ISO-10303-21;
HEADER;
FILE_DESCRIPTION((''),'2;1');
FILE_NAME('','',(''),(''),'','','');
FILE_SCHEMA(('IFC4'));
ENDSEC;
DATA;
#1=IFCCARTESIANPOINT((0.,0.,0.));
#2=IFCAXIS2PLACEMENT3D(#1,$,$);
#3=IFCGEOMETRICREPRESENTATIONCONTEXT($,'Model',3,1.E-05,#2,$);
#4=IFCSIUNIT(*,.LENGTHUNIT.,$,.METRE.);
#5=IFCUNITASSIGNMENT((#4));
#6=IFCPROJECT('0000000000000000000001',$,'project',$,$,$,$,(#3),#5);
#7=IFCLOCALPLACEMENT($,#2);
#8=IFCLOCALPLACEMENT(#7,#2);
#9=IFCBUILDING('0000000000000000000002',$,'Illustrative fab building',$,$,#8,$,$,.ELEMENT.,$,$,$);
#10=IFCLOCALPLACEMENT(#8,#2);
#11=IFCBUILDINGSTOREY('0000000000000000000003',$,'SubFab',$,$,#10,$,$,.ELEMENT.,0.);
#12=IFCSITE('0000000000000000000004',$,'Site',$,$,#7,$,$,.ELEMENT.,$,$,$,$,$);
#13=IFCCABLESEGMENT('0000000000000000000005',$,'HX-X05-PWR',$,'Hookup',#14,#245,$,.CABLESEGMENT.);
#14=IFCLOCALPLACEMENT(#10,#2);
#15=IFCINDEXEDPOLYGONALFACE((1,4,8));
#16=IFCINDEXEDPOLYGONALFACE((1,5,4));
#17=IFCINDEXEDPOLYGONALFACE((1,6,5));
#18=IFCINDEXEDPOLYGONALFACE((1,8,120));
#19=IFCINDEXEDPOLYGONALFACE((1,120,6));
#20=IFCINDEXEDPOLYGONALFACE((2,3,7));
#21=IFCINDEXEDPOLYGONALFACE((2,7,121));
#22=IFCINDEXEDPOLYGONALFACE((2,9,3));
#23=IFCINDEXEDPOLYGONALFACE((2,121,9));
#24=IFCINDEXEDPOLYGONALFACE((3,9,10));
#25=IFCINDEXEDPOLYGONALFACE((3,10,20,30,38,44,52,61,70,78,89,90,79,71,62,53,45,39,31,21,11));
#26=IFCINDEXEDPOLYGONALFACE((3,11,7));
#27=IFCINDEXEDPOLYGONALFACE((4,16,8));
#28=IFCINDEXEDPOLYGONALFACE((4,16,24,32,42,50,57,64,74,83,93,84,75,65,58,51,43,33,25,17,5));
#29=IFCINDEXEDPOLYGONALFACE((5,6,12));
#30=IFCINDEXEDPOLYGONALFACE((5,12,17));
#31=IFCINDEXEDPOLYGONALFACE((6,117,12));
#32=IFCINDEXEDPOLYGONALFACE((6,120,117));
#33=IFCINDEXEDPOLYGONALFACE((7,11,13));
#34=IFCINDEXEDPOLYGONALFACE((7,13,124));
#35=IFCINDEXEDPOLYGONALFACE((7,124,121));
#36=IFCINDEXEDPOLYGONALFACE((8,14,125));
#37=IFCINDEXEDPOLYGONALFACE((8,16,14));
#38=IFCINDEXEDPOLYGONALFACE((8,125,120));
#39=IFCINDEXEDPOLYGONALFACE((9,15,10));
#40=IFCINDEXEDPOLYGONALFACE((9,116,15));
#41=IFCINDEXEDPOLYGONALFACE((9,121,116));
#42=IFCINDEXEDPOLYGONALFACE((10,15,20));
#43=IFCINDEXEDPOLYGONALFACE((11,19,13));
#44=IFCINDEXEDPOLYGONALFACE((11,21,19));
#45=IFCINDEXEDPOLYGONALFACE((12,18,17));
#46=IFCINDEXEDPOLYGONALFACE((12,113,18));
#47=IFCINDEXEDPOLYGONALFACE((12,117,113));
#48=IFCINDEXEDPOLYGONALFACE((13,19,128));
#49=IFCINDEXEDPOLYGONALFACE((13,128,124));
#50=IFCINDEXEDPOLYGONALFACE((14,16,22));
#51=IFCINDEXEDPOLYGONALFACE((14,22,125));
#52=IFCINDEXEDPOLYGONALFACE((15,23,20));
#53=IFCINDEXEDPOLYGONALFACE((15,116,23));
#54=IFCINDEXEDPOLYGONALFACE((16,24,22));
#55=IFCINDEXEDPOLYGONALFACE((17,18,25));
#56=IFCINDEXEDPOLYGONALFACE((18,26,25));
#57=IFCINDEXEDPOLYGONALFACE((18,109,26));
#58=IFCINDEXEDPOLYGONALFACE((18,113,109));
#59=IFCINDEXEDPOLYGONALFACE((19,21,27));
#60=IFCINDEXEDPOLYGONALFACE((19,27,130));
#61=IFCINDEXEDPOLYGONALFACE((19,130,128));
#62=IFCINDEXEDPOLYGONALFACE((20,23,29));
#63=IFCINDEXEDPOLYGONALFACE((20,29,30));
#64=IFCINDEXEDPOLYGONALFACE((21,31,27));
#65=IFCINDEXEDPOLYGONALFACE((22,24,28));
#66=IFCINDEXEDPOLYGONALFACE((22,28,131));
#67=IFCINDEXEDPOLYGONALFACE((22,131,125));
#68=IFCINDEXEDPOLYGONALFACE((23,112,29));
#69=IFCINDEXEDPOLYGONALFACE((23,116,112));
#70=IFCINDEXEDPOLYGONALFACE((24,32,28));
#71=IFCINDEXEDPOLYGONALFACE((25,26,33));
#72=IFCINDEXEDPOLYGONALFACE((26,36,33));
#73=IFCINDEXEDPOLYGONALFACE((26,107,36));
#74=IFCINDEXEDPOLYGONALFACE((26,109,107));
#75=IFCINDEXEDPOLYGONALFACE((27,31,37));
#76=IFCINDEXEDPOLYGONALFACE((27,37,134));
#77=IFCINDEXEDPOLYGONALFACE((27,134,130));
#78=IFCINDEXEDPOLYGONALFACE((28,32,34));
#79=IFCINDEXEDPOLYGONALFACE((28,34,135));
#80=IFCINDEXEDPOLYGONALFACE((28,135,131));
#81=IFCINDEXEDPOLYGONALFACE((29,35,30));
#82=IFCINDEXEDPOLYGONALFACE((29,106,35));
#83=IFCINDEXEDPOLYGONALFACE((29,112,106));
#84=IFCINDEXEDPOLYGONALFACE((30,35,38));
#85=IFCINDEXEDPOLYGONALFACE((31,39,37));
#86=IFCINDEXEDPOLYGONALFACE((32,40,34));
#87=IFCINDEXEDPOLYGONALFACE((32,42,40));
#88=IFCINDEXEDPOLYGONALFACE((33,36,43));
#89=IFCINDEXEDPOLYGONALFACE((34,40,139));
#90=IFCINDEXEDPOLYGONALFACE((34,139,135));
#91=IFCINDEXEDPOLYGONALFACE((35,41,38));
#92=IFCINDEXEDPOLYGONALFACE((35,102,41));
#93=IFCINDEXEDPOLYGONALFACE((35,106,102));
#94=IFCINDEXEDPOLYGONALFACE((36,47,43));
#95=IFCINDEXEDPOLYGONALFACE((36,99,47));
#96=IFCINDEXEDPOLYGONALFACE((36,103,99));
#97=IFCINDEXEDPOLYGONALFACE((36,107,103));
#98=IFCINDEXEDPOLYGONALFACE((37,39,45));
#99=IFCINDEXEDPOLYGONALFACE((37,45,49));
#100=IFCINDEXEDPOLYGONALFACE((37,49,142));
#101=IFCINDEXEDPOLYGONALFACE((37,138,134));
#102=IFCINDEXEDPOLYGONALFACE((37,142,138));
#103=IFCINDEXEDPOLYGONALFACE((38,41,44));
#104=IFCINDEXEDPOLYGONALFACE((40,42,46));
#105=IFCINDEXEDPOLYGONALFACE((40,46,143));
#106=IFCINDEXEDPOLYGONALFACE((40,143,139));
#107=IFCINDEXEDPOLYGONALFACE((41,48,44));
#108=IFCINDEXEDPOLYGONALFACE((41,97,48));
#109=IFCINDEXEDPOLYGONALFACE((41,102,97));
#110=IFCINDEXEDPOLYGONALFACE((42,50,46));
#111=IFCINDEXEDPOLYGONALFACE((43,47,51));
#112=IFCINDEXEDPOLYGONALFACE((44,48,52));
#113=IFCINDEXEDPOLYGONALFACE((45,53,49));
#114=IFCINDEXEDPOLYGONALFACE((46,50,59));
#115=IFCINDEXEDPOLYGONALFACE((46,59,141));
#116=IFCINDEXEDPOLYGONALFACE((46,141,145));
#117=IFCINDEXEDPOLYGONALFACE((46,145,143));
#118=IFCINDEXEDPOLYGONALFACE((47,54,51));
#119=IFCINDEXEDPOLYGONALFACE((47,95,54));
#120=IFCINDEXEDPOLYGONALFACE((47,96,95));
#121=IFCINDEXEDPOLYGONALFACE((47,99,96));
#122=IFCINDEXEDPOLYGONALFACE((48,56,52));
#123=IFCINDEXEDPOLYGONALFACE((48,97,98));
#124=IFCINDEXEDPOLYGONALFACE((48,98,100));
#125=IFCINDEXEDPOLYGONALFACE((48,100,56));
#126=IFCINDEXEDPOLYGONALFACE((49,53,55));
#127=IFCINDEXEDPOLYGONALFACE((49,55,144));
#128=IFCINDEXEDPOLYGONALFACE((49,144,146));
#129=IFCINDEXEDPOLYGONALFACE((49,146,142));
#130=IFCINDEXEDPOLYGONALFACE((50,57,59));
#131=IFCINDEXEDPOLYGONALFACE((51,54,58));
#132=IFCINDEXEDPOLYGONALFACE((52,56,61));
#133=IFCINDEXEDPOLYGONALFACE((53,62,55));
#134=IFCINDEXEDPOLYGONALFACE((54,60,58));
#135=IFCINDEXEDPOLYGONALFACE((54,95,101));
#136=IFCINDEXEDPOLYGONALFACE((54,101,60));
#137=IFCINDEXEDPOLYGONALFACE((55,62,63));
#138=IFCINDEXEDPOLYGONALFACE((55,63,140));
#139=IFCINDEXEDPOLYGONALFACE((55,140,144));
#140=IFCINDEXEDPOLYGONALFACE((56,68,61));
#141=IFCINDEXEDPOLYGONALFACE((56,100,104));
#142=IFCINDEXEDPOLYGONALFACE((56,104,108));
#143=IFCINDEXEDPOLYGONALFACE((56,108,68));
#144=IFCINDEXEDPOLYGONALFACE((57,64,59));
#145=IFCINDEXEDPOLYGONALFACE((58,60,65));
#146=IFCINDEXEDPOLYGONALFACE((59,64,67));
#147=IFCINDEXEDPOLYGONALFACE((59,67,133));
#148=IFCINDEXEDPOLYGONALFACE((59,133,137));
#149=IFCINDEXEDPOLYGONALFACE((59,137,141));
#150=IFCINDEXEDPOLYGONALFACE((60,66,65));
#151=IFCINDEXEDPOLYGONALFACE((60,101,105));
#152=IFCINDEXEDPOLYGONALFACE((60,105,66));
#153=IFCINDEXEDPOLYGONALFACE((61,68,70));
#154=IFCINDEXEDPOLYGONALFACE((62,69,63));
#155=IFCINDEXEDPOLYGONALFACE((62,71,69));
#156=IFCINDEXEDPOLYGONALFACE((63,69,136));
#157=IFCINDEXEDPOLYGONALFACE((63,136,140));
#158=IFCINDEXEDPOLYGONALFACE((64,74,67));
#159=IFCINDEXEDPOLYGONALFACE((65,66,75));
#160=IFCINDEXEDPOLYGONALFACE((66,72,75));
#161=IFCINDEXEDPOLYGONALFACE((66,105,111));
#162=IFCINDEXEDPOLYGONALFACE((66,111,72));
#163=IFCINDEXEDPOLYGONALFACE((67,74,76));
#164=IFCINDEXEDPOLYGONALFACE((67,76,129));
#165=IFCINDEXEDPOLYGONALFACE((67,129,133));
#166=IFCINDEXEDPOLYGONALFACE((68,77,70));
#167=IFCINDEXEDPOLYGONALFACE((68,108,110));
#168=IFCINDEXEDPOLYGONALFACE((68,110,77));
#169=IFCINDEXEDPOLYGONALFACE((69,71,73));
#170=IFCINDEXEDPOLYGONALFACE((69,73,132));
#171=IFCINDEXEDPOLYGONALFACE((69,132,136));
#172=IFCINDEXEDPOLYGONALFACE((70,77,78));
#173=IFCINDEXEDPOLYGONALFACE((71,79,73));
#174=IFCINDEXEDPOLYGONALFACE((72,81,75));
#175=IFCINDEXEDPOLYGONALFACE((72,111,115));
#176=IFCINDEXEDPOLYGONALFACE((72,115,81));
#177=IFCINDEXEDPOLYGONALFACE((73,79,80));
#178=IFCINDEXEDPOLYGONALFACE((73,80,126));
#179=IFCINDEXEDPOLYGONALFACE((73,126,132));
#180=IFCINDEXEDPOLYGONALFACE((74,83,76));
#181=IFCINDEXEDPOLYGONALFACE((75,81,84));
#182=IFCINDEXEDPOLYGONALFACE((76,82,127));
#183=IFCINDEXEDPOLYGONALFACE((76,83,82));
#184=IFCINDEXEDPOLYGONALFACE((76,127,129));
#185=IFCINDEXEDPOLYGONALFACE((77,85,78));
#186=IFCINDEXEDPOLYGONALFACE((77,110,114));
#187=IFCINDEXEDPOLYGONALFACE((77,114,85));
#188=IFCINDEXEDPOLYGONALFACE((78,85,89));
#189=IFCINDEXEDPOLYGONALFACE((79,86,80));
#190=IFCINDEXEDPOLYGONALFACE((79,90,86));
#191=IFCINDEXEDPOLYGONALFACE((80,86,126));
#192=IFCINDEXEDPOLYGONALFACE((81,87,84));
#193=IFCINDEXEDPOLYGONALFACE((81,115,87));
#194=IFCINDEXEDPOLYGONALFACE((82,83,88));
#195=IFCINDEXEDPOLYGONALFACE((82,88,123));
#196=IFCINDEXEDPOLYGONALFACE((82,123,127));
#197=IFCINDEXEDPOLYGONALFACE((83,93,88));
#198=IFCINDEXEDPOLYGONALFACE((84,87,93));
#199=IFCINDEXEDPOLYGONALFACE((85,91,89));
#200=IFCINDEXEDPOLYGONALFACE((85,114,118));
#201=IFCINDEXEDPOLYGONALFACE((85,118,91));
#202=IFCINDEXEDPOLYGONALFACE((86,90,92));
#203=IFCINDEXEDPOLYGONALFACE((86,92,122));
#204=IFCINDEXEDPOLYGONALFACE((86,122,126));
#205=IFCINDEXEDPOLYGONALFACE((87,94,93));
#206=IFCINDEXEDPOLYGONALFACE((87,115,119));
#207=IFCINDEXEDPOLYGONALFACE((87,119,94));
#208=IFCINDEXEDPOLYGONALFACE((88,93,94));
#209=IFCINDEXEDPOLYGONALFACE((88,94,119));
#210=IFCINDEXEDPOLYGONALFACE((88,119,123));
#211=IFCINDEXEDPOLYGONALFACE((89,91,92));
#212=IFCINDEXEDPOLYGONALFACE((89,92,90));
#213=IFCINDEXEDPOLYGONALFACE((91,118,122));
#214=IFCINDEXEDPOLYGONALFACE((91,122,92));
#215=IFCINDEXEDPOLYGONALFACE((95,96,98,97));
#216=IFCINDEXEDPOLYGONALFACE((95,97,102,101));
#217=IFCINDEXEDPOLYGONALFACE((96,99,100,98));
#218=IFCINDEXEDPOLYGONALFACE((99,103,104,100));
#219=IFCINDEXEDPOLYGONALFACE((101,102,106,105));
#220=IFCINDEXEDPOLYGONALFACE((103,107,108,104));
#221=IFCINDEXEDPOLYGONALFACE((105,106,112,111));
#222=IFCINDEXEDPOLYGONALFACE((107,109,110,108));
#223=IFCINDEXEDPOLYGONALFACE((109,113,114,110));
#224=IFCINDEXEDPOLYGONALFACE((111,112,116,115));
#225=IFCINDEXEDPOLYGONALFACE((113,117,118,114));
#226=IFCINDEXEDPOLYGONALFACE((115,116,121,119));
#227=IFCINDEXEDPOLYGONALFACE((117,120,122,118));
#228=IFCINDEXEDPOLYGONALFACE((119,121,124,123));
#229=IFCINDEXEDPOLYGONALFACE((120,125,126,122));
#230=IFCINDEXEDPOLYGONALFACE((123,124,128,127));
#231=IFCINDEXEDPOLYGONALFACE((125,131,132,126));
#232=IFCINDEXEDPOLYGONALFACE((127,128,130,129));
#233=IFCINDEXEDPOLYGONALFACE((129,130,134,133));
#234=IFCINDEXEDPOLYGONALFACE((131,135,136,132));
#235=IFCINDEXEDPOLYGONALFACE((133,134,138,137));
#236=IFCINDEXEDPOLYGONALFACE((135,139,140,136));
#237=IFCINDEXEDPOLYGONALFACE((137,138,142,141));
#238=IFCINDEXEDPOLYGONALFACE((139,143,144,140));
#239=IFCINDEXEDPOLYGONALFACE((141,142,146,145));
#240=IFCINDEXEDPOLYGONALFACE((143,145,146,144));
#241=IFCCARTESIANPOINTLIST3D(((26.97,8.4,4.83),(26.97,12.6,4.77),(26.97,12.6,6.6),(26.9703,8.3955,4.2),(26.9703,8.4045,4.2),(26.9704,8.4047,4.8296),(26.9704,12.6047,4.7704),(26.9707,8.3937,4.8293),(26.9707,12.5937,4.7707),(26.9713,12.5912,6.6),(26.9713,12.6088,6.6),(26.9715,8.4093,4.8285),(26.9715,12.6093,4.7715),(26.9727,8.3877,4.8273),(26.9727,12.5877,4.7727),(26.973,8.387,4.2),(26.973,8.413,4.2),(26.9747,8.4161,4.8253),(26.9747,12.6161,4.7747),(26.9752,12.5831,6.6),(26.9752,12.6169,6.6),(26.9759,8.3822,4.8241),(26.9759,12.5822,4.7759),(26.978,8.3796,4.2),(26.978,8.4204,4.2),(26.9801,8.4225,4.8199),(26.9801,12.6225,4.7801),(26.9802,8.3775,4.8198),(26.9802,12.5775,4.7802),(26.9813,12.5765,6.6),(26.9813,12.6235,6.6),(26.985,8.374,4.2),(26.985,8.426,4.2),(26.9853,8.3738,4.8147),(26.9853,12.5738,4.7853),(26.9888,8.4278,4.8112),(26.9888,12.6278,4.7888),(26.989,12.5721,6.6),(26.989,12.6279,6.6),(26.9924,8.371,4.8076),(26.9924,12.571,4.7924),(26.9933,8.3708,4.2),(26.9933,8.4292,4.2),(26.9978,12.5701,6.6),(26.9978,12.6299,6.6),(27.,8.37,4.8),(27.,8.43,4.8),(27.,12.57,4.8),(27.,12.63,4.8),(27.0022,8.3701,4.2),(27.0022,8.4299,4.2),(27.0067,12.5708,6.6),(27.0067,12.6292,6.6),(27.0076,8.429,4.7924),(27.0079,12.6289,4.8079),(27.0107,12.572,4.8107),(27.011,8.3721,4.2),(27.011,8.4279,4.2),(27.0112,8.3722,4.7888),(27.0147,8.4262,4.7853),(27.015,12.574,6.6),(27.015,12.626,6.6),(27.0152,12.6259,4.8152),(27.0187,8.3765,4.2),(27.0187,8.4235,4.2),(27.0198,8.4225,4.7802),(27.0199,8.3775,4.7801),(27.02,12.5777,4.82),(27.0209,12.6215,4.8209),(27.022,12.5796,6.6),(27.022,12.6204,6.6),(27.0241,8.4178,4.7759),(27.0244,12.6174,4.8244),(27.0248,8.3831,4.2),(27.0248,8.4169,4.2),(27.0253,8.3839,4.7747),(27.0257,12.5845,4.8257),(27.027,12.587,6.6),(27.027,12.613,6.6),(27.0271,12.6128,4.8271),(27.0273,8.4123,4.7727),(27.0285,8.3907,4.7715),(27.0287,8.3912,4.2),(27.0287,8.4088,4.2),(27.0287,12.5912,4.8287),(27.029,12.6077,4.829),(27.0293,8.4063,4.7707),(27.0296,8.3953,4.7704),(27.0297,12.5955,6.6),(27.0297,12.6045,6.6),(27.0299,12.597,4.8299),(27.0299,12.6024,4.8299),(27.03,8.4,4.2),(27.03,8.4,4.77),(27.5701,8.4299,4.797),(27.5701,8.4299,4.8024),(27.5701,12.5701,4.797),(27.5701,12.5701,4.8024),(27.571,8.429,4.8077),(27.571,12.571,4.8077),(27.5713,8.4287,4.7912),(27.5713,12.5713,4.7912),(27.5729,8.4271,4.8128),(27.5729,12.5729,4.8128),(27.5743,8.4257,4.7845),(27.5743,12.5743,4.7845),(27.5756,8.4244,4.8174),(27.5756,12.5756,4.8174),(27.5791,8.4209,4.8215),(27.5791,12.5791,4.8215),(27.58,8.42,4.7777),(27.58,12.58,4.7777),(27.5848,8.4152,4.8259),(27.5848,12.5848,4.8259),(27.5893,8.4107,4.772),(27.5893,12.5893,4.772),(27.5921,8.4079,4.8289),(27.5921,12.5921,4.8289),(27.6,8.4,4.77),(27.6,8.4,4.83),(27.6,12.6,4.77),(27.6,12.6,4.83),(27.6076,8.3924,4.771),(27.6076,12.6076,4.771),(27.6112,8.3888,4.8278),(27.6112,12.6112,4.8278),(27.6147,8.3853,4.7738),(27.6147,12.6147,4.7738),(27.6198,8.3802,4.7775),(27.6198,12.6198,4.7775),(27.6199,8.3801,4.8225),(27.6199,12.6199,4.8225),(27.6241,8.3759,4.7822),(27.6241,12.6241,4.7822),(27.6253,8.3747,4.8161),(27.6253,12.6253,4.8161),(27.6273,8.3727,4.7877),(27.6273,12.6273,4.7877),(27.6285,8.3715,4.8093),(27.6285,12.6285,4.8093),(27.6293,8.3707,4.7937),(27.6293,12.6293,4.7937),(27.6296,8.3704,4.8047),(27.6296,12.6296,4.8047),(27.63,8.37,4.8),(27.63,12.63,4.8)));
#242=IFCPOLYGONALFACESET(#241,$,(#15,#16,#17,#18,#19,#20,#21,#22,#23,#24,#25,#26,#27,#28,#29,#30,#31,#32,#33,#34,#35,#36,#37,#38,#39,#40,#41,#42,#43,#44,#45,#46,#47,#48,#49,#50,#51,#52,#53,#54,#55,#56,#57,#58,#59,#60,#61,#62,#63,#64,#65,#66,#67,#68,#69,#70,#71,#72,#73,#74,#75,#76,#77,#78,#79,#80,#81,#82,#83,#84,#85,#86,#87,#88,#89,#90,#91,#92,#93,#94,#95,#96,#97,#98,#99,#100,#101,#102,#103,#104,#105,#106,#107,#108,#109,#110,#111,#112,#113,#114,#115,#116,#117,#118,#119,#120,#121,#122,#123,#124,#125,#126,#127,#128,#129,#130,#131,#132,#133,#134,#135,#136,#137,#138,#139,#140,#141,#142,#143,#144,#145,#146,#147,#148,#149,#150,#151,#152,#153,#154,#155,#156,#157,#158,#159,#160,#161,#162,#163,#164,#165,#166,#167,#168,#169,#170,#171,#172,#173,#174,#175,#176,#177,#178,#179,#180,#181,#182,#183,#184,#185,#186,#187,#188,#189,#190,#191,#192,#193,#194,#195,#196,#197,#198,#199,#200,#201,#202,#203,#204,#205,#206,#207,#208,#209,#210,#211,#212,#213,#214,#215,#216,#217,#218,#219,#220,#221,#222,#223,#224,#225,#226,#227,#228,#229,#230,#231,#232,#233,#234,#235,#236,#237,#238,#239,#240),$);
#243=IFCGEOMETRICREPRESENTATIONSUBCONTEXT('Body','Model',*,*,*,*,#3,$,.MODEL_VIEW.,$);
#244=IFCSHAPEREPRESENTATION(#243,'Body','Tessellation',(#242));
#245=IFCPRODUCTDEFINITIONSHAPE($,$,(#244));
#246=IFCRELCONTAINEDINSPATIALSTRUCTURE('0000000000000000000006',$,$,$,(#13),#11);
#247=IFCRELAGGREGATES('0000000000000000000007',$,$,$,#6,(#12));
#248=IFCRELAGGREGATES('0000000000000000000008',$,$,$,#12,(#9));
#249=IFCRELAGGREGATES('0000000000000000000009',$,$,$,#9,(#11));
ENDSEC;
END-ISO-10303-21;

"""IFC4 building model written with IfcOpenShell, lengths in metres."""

from ifc_helpers import new_model, entity, si_unit, origin, place, context, subcontext, project, spatial, element, save


model = new_model("IFC4")

# Units and contexts
model_context = context("Model", 3, precision=1e-05, world=origin())
body_context = subcontext(model_context, "Body", "Model", "MODEL_VIEW")
ifc_project = project(units=[si_unit("LENGTHUNIT", "METRE")], contexts=[model_context])

# Site, building, storey
site_placement = place(None, origin())
site = spatial("IfcSite", under=ifc_project, at=site_placement, Name="Site", CompositionType="ELEMENT")
building_placement = place(site_placement, origin())
building = spatial("IfcBuilding", under=site, at=building_placement, Name="Illustrative fab building", CompositionType="ELEMENT")
storey_placement = place(building_placement, origin())
storey = spatial("IfcBuildingStorey", under=building, at=storey_placement, Name="SubFab", CompositionType="ELEMENT", Elevation=0.0)

# Cable segment
cable_segment_1_placement = place(storey_placement, origin())
element("IfcCableSegment", 1, at=cable_segment_1_placement, inside=storey, Name="HX-X05-PWR", ObjectType="Hookup", PredefinedType="CABLESEGMENT", context=body_context, shape_type="AdvancedSweptSolid", body=[
    entity("IfcSweptDiskSolid", entity("IfcPolyline", [entity("IfcCartesianPoint", [27.0, 8.4, 4.2]), entity("IfcCartesianPoint", [27.0, 8.4, 4.8]), entity("IfcCartesianPoint", [27.6, 8.4, 4.8]), entity("IfcCartesianPoint", [27.6, 12.6, 4.8]), entity("IfcCartesianPoint", [27.0, 12.6, 4.8]), entity("IfcCartesianPoint", [27.0, 12.6, 6.6])]), 0.03),
])

save(model, "model.ifc")
